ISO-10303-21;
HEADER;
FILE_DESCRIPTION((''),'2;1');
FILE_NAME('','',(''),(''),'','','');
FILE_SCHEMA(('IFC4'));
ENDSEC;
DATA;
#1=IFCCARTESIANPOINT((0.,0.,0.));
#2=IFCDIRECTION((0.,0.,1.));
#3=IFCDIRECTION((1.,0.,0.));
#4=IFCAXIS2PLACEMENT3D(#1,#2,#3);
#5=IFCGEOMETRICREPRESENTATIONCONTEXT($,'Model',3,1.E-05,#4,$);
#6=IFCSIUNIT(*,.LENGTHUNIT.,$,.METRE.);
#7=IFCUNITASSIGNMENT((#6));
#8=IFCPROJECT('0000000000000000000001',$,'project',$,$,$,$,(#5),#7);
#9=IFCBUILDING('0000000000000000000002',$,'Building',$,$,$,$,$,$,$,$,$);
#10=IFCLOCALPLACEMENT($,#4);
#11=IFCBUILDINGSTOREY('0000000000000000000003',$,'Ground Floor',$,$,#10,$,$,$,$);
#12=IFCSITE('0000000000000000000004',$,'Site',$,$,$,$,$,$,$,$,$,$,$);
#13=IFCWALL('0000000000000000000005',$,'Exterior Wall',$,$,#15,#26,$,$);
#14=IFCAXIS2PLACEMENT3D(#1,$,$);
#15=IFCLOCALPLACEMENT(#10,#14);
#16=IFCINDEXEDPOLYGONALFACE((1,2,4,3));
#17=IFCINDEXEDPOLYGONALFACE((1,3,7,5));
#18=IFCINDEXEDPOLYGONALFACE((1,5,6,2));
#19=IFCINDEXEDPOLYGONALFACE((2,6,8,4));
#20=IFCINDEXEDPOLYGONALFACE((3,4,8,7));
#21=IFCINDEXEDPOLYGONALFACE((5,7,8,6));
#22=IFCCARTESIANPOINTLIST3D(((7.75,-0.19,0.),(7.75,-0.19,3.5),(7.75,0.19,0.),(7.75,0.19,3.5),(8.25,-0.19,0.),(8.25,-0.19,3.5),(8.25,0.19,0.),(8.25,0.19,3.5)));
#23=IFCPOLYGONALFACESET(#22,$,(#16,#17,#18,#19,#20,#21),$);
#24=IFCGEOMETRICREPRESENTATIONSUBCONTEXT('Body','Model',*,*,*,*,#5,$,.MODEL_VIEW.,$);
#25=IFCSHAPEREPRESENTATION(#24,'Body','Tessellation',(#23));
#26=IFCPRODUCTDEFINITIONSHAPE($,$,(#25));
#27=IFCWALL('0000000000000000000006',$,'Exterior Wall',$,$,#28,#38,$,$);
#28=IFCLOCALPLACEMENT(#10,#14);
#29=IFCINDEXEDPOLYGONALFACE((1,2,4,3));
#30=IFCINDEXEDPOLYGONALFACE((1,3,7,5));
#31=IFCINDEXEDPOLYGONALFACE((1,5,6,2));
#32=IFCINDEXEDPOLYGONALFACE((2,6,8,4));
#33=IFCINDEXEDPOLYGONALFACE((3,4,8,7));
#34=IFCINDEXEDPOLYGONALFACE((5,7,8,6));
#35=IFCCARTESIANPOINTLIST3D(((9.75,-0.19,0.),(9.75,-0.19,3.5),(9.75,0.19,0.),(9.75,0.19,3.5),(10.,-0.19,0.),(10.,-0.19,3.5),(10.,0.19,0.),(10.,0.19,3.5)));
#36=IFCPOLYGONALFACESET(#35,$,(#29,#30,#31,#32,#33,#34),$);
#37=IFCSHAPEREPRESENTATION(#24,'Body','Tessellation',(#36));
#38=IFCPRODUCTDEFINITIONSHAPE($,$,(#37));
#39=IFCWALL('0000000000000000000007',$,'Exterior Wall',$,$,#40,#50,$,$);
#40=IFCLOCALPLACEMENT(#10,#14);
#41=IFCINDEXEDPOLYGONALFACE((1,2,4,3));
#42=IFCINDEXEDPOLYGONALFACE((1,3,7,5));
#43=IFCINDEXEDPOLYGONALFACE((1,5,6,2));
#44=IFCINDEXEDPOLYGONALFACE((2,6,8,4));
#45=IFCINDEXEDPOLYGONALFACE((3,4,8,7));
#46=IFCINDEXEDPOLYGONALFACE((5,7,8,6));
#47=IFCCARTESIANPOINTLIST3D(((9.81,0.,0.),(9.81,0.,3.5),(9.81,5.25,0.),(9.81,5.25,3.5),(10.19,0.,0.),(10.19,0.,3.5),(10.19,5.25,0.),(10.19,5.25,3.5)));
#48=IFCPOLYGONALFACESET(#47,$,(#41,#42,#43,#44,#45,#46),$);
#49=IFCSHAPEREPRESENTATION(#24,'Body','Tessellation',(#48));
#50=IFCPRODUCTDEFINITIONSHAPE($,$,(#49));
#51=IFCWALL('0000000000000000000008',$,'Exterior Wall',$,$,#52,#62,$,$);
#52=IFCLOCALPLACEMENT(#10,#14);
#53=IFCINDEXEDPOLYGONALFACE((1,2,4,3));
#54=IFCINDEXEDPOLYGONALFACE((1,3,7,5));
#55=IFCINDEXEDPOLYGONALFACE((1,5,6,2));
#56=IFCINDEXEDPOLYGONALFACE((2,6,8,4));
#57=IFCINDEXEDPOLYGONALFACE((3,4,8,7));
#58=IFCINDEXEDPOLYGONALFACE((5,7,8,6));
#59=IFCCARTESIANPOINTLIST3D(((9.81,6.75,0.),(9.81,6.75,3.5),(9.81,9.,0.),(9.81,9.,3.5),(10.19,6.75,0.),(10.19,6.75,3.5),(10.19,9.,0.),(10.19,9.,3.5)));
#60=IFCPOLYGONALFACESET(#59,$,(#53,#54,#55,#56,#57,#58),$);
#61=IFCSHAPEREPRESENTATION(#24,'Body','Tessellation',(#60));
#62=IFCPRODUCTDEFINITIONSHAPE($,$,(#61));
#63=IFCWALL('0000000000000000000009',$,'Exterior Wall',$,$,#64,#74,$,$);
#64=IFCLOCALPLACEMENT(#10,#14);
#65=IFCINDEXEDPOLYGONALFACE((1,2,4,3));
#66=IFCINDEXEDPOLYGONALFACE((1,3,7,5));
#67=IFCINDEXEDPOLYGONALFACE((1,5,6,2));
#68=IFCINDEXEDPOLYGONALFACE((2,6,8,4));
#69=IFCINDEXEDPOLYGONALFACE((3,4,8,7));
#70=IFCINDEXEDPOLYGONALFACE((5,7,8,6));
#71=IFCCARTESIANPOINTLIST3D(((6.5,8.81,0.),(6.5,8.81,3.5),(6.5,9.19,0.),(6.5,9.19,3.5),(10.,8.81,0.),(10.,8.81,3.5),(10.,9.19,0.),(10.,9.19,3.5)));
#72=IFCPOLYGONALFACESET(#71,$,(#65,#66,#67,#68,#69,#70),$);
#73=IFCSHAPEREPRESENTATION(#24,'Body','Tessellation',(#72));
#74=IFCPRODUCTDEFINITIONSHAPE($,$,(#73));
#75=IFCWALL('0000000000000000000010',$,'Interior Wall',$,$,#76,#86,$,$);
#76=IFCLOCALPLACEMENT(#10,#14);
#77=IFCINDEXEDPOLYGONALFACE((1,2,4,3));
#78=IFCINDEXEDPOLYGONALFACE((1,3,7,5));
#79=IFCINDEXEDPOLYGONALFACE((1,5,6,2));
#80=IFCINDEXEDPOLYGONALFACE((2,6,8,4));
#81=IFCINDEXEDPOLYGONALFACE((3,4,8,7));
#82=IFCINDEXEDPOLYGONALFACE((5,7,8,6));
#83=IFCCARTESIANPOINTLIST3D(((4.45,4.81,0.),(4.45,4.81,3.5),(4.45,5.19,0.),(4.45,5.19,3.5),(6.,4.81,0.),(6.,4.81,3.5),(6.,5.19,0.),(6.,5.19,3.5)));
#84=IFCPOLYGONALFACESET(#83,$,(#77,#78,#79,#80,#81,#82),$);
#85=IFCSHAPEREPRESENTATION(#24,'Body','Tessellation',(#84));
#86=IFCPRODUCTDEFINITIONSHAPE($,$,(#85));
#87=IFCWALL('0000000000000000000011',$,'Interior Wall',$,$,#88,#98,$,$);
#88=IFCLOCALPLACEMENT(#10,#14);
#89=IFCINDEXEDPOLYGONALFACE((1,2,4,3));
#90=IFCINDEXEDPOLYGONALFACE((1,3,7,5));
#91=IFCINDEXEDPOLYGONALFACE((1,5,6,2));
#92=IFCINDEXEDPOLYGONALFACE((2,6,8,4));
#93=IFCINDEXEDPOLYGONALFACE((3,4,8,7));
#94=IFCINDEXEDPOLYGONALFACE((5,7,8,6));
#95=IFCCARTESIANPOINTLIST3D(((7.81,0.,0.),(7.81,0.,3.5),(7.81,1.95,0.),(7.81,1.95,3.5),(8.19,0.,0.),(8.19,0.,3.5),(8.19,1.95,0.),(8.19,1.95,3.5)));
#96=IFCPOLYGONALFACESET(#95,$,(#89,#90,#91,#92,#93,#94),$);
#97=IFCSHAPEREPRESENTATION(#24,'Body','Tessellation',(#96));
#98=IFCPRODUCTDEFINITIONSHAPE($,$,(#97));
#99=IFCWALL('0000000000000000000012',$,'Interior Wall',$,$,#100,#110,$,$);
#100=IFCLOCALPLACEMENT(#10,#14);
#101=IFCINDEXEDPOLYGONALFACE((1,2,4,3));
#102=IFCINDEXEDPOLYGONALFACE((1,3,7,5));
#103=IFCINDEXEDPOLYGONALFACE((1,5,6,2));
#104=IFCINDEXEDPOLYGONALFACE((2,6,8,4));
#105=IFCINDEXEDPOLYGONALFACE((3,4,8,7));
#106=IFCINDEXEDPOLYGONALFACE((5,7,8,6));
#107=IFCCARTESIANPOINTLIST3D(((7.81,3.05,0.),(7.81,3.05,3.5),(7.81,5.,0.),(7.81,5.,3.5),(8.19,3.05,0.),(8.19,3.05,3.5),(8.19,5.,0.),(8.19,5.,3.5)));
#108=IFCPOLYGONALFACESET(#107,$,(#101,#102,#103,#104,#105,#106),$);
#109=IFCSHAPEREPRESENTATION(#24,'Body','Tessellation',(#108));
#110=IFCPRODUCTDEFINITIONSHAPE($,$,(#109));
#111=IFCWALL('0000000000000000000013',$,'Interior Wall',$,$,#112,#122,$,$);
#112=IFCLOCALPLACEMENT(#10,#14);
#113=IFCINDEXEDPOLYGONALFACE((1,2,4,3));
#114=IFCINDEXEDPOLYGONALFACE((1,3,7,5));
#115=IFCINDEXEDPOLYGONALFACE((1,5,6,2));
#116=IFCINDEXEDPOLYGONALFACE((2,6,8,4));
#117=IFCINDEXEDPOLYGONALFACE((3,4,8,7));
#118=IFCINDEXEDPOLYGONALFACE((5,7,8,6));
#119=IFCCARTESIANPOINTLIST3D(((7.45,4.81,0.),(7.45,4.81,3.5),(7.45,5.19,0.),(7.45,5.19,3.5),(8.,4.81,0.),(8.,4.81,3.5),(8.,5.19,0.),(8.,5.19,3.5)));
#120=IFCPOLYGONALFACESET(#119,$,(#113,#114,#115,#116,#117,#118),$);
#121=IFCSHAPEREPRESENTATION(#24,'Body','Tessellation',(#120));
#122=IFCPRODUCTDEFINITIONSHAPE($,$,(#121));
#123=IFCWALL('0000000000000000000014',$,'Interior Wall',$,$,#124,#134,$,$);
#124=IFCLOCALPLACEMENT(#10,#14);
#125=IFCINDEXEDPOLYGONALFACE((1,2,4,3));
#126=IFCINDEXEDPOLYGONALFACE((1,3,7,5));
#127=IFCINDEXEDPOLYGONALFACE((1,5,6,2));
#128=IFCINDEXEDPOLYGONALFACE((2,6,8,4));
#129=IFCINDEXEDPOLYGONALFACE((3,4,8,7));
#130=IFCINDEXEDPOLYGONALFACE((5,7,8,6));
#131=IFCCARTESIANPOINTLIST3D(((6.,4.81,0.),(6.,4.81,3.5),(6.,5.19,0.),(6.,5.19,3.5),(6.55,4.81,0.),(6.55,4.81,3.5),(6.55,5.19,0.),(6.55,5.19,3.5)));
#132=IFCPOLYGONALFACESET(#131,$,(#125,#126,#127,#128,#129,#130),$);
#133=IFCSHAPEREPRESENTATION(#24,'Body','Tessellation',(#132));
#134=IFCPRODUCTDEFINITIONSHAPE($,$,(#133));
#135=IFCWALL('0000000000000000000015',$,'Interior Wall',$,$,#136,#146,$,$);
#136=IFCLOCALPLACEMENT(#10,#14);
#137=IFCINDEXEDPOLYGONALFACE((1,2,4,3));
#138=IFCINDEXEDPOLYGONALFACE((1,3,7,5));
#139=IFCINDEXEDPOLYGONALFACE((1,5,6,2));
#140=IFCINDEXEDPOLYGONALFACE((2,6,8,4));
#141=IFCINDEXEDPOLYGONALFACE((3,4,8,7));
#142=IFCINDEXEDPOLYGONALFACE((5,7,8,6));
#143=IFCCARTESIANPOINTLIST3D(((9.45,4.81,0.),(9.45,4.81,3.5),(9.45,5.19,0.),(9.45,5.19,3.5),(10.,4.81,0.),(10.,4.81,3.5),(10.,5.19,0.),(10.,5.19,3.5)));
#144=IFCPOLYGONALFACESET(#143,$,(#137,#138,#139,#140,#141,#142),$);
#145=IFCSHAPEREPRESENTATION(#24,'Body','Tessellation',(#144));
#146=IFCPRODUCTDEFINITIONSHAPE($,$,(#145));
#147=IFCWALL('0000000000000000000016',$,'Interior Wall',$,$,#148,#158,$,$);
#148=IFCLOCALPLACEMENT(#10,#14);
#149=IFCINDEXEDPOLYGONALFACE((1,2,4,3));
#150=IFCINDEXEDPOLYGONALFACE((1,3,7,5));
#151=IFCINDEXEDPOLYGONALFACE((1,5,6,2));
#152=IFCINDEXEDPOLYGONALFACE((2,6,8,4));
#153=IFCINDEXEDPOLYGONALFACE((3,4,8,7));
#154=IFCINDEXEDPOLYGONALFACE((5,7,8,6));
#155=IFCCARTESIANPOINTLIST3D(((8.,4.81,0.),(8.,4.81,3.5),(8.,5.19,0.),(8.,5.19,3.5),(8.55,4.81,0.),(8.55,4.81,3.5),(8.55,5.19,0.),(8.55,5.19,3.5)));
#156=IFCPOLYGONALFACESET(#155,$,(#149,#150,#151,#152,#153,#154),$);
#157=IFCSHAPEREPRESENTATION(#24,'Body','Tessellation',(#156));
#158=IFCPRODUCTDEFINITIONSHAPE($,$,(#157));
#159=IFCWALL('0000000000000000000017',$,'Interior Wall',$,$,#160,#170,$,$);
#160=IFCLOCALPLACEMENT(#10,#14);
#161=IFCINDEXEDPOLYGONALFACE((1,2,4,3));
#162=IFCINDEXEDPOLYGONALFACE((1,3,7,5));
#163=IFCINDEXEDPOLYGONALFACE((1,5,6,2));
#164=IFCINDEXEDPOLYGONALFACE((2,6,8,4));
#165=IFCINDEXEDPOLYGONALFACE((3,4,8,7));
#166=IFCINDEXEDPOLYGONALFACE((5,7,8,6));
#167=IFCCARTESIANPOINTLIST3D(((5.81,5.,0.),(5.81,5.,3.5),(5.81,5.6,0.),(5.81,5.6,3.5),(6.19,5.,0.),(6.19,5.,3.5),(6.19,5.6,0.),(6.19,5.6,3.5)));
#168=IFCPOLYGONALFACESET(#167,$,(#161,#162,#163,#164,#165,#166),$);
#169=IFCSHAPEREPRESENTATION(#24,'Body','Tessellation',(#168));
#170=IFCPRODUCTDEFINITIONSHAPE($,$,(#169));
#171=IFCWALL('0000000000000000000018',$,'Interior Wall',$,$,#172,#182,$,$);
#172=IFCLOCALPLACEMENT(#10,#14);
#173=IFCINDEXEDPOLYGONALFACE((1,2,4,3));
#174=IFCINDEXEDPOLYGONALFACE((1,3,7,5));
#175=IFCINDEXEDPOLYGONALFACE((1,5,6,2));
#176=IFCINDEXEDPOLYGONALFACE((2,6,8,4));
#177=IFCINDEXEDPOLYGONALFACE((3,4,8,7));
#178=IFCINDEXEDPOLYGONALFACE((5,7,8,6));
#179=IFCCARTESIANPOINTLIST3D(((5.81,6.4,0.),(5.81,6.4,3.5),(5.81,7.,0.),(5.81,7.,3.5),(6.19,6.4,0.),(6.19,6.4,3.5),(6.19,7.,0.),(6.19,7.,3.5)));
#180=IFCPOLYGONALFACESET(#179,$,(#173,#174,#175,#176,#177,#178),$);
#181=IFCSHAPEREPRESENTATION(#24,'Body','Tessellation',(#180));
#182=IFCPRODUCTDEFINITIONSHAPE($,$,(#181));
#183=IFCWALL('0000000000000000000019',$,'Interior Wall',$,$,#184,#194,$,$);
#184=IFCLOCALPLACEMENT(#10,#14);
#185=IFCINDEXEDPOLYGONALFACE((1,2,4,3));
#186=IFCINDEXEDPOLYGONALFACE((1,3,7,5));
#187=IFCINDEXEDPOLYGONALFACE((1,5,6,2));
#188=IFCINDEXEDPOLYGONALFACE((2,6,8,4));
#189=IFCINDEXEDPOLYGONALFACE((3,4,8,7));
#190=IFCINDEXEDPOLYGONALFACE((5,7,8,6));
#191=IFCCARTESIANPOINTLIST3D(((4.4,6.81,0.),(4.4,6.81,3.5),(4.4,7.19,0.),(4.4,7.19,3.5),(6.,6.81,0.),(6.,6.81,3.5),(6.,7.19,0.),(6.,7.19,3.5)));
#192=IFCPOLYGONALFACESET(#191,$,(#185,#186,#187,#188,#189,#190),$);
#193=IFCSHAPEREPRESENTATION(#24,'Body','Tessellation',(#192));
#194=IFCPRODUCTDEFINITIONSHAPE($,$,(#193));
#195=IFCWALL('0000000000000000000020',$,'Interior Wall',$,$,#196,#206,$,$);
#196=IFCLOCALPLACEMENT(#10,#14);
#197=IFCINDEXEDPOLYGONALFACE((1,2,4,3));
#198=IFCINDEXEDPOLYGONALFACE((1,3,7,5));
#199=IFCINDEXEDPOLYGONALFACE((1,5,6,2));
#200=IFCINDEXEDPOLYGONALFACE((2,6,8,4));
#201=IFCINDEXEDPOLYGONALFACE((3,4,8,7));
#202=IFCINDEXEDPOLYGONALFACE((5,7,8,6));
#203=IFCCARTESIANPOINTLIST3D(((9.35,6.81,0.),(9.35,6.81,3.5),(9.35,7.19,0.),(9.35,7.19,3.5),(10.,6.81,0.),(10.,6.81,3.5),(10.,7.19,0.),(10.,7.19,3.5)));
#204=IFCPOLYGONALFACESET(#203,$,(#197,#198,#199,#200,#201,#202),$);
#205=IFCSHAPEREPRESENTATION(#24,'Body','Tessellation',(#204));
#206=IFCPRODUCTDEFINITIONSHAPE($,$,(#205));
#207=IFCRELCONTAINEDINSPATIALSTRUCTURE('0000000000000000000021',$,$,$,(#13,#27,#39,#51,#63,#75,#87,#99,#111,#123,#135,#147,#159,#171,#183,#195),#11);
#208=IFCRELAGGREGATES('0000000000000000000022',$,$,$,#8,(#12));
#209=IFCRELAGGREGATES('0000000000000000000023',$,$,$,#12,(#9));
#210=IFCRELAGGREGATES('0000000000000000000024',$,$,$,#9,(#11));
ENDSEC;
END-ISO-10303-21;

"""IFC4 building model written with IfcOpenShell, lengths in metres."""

from ifc_helpers import new_model, si_unit, frame, origin_with_axes, place, context, subcontext, project, spatial, indexed_curve, outline, extrude, element, save


model = new_model("IFC4")

# Units and contexts
model_context = context("Model", 3, precision=1e-05, world=origin_with_axes())
body_context = subcontext(model_context, "Body", "Model", "MODEL_VIEW")
ifc_project = project(units=[si_unit("LENGTHUNIT", "METRE")], contexts=[model_context])

# Site, building, storey
site = spatial("IfcSite", under=ifc_project, Name="Site")
building = spatial("IfcBuilding", under=site, Name="Building")
storey_placement = place(None, origin_with_axes())
storey = spatial("IfcBuildingStorey", under=building, at=storey_placement, Name="Ground Floor")

# Walls
wall_1_placement = place(storey_placement, frame((7.75, 0.0, 0.0), z_axis=(0.0, 0.0, 1.0), x_axis=(1.0, 0.0, 0.0)))
element("IfcWall", 1, at=wall_1_placement, inside=storey, Name="Exterior Wall", context=body_context, shape_type="SweptSolid", body=[
    extrude(outline(indexed_curve([(0.0, 0.0), (0.0, 0.38), (0.5, 0.38), (0.5, 0.0), (0.0, 0.0)], self_intersect=False)), frame((0.0, -0.19, 0.0), z_axis=(0.0, 0.0, 1.0), x_axis=(1.0, 0.0, 0.0)), (0.0, 0.0, 1.0), 3.5),
])
wall_2_placement = place(storey_placement, frame((9.75, 0.0, 0.0), z_axis=(0.0, 0.0, 1.0), x_axis=(1.0, 0.0, 0.0)))
element("IfcWall", 2, at=wall_2_placement, inside=storey, Name="Exterior Wall", context=body_context, shape_type="SweptSolid", body=[
    extrude(outline(indexed_curve([(0.0, 0.0), (0.0, 0.38), (0.25, 0.38), (0.25, 0.0), (0.0, 0.0)], self_intersect=False)), frame((0.0, -0.19, 0.0), z_axis=(0.0, 0.0, 1.0), x_axis=(1.0, 0.0, 0.0)), (0.0, 0.0, 1.0), 3.5),
])
wall_3_placement = place(storey_placement, frame((10.0, 0.0, 0.0), z_axis=(0.0, 0.0, 1.0), x_axis=(0.0, 1.0, 0.0)))
element("IfcWall", 3, at=wall_3_placement, inside=storey, Name="Exterior Wall", context=body_context, shape_type="SweptSolid", body=[
    extrude(outline(indexed_curve([(0.0, 0.0), (0.0, 0.38), (5.25, 0.38), (5.25, 0.0), (0.0, 0.0)], self_intersect=False)), frame((0.0, -0.19, 0.0), z_axis=(0.0, 0.0, 1.0), x_axis=(1.0, 0.0, 0.0)), (0.0, 0.0, 1.0), 3.5),
])
wall_4_placement = place(storey_placement, frame((10.0, 6.75, 0.0), z_axis=(0.0, 0.0, 1.0), x_axis=(0.0, 1.0, 0.0)))
element("IfcWall", 4, at=wall_4_placement, inside=storey, Name="Exterior Wall", context=body_context, shape_type="SweptSolid", body=[
    extrude(outline(indexed_curve([(0.0, 0.0), (0.0, 0.38), (2.25, 0.38), (2.25, 0.0), (0.0, 0.0)], self_intersect=False)), frame((0.0, -0.19, 0.0), z_axis=(0.0, 0.0, 1.0), x_axis=(1.0, 0.0, 0.0)), (0.0, 0.0, 1.0), 3.5),
])
wall_5_placement = place(storey_placement, frame((10.0, 9.0, 0.0), z_axis=(0.0, 0.0, 1.0), x_axis=(-1.0, 0.0, 0.0)))
element("IfcWall", 5, at=wall_5_placement, inside=storey, Name="Exterior Wall", context=body_context, shape_type="SweptSolid", body=[
    extrude(outline(indexed_curve([(0.0, 0.0), (0.0, 0.38), (3.5, 0.38), (3.5, 0.0), (0.0, 0.0)], self_intersect=False)), frame((0.0, -0.19, 0.0), z_axis=(0.0, 0.0, 1.0), x_axis=(1.0, 0.0, 0.0)), (0.0, 0.0, 1.0), 3.5),
])
wall_6_placement = place(storey_placement, frame((6.0, 5.0, 0.0), z_axis=(0.0, 0.0, 1.0), x_axis=(-1.0, 0.0, 0.0)))
element("IfcWall", 6, at=wall_6_placement, inside=storey, Name="Interior Wall", context=body_context, shape_type="SweptSolid", body=[
    extrude(outline(indexed_curve([(0.0, 0.0), (0.0, 0.38), (1.55, 0.38), (1.55, 0.0), (0.0, 0.0)], self_intersect=False)), frame((0.0, -0.19, 0.0), z_axis=(0.0, 0.0, 1.0), x_axis=(1.0, 0.0, 0.0)), (0.0, 0.0, 1.0), 3.5),
])
wall_7_placement = place(storey_placement, frame((8.0, 0.0, 0.0), z_axis=(0.0, 0.0, 1.0), x_axis=(0.0, 1.0, 0.0)))
element("IfcWall", 7, at=wall_7_placement, inside=storey, Name="Interior Wall", context=body_context, shape_type="SweptSolid", body=[
    extrude(outline(indexed_curve([(0.0, 0.0), (0.0, 0.38), (1.95, 0.38), (1.95, 0.0), (0.0, 0.0)], self_intersect=False)), frame((0.0, -0.19, 0.0), z_axis=(0.0, 0.0, 1.0), x_axis=(1.0, 0.0, 0.0)), (0.0, 0.0, 1.0), 3.5),
])
wall_8_placement = place(storey_placement, frame((8.0, 3.05, 0.0), z_axis=(0.0, 0.0, 1.0), x_axis=(0.0, 1.0, 0.0)))
element("IfcWall", 8, at=wall_8_placement, inside=storey, Name="Interior Wall", context=body_context, shape_type="SweptSolid", body=[
    extrude(outline(indexed_curve([(0.0, 0.0), (0.0, 0.38), (1.95, 0.38), (1.95, 0.0), (0.0, 0.0)], self_intersect=False)), frame((0.0, -0.19, 0.0), z_axis=(0.0, 0.0, 1.0), x_axis=(1.0, 0.0, 0.0)), (0.0, 0.0, 1.0), 3.5),
])
for number, where, z_axis, x_axis, name in (
    (9, (8.0, 5.0, 0.0), (0.0, 0.0, 1.0), (-1.0, 0.0, 0.0), "Interior Wall"),
    (10, (6.55, 5.0, 0.0), (0.0, 0.0, 1.0), (-1.0, 0.0, 0.0), "Interior Wall"),
):
    element("IfcWall", number, at=place(storey_placement, frame(where, z_axis=z_axis, x_axis=x_axis)), inside=storey, Name=name, context=body_context, shape_type="SweptSolid", body=[
        extrude(outline(indexed_curve([(0.0, 0.0), (0.0, 0.38), (0.55, 0.38), (0.55, 0.0), (0.0, 0.0)], self_intersect=False)), frame((0.0, -0.19, 0.0), z_axis=(0.0, 0.0, 1.0), x_axis=(1.0, 0.0, 0.0)), (0.0, 0.0, 1.0), 3.5),
    ])
for number, where, z_axis, x_axis, name in (
    (11, (10.0, 5.0, 0.0), (0.0, 0.0, 1.0), (-1.0, 0.0, 0.0), "Interior Wall"),
    (12, (8.55, 5.0, 0.0), (0.0, 0.0, 1.0), (-1.0, 0.0, 0.0), "Interior Wall"),
):
    element("IfcWall", number, at=place(storey_placement, frame(where, z_axis=z_axis, x_axis=x_axis)), inside=storey, Name=name, context=body_context, shape_type="SweptSolid", body=[
        extrude(outline(indexed_curve([(0.0, 0.0), (0.0, 0.38), (0.55, 0.38), (0.55, 0.0), (0.0, 0.0)], self_intersect=False)), frame((0.0, -0.19, 0.0), z_axis=(0.0, 0.0, 1.0), x_axis=(1.0, 0.0, 0.0)), (0.0, 0.0, 1.0), 3.5),
    ])
for number, where, z_axis, x_axis, name in (
    (13, (6.0, 5.0, 0.0), (0.0, 0.0, 1.0), (0.0, 1.0, 0.0), "Interior Wall"),
    (14, (6.0, 6.4, 0.0), (0.0, 0.0, 1.0), (0.0, 1.0, 0.0), "Interior Wall"),
):
    element("IfcWall", number, at=place(storey_placement, frame(where, z_axis=z_axis, x_axis=x_axis)), inside=storey, Name=name, context=body_context, shape_type="SweptSolid", body=[
        extrude(outline(indexed_curve([(0.0, 0.0), (0.0, 0.38), (0.6, 0.38), (0.6, 0.0), (0.0, 0.0)], self_intersect=False)), frame((0.0, -0.19, 0.0), z_axis=(0.0, 0.0, 1.0), x_axis=(1.0, 0.0, 0.0)), (0.0, 0.0, 1.0), 3.5),
    ])
wall_9_placement = place(storey_placement, frame((6.0, 7.0, 0.0), z_axis=(0.0, 0.0, 1.0), x_axis=(-1.0, 0.0, 0.0)))
element("IfcWall", 15, at=wall_9_placement, inside=storey, Name="Interior Wall", context=body_context, shape_type="SweptSolid", body=[
    extrude(outline(indexed_curve([(0.0, 0.0), (0.0, 0.38), (1.6, 0.38), (1.6, 0.0), (0.0, 0.0)], self_intersect=False)), frame((0.0, -0.19, 0.0), z_axis=(0.0, 0.0, 1.0), x_axis=(1.0, 0.0, 0.0)), (0.0, 0.0, 1.0), 3.5),
])
for number, where, z_axis, x_axis, name in (
    (16, (10.0, 7.0, 0.0), (0.0, 0.0, 1.0), (-1.0, 0.0, 0.0), "Interior Wall"),
):
    element("IfcWall", number, at=place(storey_placement, frame(where, z_axis=z_axis, x_axis=x_axis)), inside=storey, Name=name, context=body_context, shape_type="SweptSolid", body=[
        extrude(outline(indexed_curve([(0.0, 0.0), (0.0, 0.38), (0.65, 0.38), (0.65, 0.0), (0.0, 0.0)], self_intersect=False)), frame((0.0, -0.19, 0.0), z_axis=(0.0, 0.0, 1.0), x_axis=(1.0, 0.0, 0.0)), (0.0, 0.0, 1.0), 3.5),
    ])

save(model, "model.ifc")
